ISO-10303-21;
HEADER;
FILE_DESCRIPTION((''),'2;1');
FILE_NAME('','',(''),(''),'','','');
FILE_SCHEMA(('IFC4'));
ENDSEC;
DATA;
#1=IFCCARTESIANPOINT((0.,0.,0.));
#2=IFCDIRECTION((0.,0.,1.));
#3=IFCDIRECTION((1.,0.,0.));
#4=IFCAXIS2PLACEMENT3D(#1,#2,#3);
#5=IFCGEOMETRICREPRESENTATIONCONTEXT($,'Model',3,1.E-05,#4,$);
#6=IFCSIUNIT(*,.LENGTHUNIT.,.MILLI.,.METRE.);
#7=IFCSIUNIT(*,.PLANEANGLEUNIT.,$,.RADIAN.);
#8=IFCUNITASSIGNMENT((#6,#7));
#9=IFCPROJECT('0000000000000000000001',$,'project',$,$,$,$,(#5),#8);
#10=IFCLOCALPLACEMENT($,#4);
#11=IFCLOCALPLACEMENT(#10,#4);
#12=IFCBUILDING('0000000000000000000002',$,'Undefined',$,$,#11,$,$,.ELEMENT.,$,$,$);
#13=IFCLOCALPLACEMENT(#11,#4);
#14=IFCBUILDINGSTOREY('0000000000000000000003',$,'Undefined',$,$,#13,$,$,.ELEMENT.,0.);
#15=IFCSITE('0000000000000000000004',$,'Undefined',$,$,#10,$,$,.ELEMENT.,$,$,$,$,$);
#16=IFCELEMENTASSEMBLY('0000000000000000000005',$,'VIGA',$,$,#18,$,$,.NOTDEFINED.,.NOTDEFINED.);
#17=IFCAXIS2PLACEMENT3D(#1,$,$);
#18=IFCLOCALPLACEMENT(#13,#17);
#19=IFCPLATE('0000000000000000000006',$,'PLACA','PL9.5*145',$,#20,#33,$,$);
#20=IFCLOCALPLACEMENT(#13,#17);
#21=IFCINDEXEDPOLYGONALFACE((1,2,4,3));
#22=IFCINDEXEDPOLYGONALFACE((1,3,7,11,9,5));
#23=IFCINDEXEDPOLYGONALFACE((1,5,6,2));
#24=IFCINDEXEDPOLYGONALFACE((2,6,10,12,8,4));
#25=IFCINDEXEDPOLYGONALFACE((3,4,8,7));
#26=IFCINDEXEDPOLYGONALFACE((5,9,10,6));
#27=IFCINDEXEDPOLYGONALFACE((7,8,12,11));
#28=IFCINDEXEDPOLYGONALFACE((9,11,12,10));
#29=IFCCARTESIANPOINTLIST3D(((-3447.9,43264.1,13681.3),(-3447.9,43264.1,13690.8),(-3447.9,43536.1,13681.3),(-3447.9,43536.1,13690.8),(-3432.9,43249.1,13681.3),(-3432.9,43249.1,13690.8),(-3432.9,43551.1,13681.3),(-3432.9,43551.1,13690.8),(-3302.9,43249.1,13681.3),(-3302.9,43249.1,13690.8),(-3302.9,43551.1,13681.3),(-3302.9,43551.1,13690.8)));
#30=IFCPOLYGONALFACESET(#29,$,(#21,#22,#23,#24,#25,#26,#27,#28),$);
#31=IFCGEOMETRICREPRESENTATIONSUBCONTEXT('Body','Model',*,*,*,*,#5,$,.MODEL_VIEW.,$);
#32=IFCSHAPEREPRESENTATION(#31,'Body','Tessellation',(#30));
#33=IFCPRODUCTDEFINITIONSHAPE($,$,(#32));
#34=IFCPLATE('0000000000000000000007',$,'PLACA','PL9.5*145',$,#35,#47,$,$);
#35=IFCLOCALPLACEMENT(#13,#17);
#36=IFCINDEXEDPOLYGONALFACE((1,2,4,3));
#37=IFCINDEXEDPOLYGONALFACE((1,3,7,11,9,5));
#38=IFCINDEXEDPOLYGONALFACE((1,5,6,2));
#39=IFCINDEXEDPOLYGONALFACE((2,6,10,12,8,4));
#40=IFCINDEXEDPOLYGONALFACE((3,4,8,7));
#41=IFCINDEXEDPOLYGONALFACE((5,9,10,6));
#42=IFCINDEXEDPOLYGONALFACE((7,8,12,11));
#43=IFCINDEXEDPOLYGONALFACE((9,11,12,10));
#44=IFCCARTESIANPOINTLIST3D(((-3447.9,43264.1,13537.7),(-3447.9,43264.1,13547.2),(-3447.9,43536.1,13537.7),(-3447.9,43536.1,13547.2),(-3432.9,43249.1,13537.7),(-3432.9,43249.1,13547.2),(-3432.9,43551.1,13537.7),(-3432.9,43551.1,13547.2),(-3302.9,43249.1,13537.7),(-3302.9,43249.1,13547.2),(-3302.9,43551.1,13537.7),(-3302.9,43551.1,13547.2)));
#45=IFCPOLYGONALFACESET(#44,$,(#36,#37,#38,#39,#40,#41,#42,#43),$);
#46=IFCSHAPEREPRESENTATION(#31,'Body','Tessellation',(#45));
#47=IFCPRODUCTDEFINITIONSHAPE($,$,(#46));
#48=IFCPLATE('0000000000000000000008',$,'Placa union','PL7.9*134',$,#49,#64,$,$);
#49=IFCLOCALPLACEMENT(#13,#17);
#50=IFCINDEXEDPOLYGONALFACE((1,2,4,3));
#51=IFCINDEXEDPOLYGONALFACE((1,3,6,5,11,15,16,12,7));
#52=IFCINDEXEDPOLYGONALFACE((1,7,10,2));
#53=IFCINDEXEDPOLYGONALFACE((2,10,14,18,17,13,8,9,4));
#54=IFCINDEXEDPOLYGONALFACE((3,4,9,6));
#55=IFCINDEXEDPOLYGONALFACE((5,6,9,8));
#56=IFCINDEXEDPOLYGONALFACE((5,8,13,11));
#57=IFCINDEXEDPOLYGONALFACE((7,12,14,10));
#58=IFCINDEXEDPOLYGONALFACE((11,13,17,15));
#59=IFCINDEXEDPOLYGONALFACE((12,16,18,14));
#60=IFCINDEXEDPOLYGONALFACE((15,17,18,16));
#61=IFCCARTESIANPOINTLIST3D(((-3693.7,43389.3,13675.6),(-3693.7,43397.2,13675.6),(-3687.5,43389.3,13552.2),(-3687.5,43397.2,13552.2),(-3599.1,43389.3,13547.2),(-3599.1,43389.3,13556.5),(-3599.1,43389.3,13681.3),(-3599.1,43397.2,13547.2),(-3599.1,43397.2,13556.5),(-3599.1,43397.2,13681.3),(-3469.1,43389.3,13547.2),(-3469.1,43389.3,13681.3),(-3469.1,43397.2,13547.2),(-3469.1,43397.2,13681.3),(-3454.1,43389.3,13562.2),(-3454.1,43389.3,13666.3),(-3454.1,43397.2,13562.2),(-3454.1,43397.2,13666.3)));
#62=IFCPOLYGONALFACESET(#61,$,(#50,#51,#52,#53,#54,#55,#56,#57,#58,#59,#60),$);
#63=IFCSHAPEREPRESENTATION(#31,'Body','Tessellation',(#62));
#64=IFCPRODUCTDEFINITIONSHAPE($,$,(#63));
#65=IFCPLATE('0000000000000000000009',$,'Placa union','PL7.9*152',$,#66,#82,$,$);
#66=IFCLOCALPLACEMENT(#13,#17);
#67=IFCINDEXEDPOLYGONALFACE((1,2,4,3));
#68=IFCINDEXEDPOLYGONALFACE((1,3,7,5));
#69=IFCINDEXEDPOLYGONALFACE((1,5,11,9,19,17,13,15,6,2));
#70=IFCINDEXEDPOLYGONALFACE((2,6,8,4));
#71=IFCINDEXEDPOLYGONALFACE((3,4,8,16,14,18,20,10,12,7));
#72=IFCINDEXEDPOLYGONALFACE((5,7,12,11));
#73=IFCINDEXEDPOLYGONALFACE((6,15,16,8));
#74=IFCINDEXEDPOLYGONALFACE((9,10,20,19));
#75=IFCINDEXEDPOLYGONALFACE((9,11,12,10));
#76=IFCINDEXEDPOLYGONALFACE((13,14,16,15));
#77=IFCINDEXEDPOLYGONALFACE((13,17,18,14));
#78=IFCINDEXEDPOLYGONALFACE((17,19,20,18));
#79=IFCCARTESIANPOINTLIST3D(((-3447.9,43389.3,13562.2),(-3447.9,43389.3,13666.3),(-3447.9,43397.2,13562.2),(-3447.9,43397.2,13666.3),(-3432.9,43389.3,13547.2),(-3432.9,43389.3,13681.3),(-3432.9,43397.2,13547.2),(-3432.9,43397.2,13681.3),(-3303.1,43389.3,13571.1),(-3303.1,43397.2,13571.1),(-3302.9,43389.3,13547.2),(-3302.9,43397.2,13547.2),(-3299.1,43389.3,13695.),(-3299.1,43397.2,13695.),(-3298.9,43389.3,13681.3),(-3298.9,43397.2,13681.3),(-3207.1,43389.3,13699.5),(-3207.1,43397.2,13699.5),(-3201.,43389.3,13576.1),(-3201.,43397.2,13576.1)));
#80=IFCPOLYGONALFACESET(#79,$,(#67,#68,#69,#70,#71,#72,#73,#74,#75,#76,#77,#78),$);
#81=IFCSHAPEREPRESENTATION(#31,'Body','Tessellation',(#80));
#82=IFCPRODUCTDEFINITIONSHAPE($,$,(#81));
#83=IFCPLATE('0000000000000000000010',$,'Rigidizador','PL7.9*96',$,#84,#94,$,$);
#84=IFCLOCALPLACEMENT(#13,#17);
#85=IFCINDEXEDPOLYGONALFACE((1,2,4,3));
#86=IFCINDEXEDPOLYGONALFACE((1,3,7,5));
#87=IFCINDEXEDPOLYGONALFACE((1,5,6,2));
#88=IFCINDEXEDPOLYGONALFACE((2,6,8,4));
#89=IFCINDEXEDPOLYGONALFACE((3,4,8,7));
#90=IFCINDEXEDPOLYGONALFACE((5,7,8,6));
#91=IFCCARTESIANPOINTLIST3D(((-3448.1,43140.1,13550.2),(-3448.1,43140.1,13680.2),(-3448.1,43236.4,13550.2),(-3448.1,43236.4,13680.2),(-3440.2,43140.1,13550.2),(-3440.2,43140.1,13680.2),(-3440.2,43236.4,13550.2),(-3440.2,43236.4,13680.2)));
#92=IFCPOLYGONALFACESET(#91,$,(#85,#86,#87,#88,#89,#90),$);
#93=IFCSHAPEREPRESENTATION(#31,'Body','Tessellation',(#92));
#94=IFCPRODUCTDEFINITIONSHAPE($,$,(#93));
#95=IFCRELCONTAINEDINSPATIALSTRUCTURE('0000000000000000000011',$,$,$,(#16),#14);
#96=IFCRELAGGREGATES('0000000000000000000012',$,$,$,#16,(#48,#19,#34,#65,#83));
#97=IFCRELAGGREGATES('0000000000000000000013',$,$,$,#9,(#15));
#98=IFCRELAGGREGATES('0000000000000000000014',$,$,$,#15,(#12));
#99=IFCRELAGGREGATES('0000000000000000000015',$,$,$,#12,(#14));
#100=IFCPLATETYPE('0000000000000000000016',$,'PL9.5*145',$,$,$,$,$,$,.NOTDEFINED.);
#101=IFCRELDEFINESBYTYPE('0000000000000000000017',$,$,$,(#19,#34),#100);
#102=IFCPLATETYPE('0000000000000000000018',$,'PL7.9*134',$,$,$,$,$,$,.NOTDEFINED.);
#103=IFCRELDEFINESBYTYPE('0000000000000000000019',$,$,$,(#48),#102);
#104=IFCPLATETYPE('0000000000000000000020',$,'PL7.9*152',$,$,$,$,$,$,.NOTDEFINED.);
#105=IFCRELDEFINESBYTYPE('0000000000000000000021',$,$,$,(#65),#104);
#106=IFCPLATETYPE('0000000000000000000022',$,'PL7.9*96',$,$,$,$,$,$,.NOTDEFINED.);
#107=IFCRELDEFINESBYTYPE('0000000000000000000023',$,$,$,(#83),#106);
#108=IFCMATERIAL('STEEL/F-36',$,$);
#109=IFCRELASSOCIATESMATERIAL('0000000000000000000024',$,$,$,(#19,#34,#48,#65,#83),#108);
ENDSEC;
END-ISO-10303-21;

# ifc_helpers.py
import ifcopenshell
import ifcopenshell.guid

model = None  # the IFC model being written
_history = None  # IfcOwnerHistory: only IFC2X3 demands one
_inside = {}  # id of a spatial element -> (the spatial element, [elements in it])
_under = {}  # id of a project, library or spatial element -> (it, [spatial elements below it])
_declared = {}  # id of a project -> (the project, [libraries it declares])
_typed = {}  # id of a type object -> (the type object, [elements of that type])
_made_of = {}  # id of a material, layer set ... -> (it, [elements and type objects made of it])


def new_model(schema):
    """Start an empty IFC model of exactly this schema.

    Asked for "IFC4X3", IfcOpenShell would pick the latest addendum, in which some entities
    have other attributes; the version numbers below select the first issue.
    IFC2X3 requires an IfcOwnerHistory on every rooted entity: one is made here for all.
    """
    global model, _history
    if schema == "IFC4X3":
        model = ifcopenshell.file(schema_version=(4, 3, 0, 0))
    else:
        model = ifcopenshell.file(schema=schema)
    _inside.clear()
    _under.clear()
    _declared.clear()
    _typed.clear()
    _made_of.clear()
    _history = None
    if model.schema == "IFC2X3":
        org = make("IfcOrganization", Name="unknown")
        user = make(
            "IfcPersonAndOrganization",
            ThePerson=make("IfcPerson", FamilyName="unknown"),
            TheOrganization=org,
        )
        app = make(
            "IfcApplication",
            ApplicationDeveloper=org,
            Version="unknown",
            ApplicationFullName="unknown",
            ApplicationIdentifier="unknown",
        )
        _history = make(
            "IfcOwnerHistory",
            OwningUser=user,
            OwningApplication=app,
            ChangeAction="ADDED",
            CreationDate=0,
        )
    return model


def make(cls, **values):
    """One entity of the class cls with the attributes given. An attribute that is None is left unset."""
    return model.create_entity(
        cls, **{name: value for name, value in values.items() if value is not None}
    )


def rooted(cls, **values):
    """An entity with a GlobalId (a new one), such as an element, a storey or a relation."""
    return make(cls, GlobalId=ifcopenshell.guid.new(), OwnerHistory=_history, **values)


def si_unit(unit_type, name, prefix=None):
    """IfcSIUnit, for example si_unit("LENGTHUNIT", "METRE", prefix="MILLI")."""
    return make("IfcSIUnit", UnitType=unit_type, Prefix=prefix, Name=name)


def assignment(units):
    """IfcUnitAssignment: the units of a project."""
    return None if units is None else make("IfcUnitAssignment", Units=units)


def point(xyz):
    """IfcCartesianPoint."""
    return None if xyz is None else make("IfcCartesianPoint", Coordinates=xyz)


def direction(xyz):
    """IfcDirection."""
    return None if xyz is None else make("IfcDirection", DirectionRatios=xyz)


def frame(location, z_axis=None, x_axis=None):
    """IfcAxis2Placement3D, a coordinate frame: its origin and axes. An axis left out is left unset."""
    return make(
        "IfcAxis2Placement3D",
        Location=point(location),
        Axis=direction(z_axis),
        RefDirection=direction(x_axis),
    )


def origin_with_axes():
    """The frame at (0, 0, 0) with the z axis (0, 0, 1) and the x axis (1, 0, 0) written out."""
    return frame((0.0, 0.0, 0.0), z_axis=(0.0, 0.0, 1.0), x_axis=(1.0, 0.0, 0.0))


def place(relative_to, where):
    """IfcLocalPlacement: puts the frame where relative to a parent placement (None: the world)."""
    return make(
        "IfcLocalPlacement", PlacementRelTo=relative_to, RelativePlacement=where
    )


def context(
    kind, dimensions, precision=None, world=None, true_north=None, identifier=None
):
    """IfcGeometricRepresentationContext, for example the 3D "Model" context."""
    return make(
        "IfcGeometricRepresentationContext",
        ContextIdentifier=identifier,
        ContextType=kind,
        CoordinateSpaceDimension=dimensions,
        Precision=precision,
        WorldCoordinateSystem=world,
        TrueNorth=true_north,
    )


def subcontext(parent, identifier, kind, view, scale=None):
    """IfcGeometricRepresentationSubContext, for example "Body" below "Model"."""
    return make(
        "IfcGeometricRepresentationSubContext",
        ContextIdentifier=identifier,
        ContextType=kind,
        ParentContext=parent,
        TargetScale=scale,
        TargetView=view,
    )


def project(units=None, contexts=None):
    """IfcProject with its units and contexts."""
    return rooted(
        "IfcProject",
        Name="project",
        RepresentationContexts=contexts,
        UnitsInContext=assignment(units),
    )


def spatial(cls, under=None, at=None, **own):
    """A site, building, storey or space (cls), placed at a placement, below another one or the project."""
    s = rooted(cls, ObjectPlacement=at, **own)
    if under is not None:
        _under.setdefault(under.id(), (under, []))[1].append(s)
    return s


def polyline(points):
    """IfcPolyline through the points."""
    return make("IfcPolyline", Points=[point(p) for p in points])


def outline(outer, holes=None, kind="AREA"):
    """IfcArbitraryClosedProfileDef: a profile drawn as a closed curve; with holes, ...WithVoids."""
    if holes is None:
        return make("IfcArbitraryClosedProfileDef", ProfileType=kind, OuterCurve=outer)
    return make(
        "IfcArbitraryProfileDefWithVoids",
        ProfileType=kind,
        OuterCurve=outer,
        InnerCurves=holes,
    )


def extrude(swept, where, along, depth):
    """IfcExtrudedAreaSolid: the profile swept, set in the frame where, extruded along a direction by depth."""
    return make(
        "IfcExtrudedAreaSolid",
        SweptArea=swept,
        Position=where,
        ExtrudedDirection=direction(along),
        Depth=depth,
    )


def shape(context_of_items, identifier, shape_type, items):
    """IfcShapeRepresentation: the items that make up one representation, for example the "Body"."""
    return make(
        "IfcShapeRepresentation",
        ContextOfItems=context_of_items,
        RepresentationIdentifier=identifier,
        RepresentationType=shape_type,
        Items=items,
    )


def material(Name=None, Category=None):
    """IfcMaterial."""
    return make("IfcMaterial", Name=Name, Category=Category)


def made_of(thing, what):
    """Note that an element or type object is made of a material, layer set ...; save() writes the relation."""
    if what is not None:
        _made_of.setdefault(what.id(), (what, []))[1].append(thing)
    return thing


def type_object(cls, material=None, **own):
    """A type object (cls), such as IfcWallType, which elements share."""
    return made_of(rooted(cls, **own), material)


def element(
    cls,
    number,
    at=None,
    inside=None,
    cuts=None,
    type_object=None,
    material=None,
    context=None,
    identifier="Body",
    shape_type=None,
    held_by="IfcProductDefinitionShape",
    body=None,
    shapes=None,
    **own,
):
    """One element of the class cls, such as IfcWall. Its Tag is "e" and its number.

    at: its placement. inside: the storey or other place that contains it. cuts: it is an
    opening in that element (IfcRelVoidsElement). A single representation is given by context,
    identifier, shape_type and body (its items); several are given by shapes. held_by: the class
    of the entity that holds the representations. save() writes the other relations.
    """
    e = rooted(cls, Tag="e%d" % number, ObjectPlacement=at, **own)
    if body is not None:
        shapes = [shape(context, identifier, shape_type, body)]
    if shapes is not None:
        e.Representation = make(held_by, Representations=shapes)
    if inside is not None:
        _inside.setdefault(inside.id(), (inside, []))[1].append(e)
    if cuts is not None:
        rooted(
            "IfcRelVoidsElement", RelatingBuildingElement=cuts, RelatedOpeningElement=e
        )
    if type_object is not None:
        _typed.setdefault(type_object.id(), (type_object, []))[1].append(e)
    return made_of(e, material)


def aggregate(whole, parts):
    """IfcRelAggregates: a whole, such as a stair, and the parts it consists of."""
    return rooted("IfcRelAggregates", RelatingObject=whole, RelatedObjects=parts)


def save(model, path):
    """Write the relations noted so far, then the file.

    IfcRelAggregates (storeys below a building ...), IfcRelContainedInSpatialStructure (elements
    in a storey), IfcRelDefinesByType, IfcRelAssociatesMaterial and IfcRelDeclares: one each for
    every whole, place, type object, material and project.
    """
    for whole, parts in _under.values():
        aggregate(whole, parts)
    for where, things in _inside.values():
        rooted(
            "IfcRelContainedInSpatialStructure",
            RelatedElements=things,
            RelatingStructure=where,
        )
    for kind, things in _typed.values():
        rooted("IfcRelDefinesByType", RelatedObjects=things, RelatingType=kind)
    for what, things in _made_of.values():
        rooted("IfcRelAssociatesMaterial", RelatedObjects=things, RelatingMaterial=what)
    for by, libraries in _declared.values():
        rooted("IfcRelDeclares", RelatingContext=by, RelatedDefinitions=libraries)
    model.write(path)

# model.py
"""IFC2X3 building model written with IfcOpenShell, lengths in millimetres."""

from ifc_helpers import new_model, si_unit, frame, origin_with_axes, place, context, subcontext, project, spatial, polyline, outline, extrude, material, type_object, element, aggregate, save


model = new_model("IFC2X3")

# Units and contexts
model_context = context("Model", 3, precision=1e-05, world=origin_with_axes())
body_context = subcontext(model_context, "Body", "Model", "MODEL_VIEW")
ifc_project = project(units=[si_unit("LENGTHUNIT", "METRE", prefix="MILLI"), si_unit("PLANEANGLEUNIT", "RADIAN")], contexts=[model_context])

# Site, building, storey
site_placement = place(None, origin_with_axes())
site = spatial("IfcSite", under=ifc_project, at=site_placement, Name="Undefined", CompositionType="ELEMENT")
building_placement = place(site_placement, origin_with_axes())
building = spatial("IfcBuilding", under=site, at=building_placement, Name="Undefined", CompositionType="ELEMENT")
storey_placement = place(building_placement, origin_with_axes())
storey = spatial("IfcBuildingStorey", under=building, at=storey_placement, Name="Undefined", CompositionType="ELEMENT", Elevation=0.0)

# Shared definitions
ifc_material_1 = material(Name="STEEL/F-36")

# Element assembly
assembly_1_placement = place(storey_placement, origin_with_axes())
assembly_1 = element("IfcElementAssembly", 1, at=assembly_1_placement, inside=storey, Name="VIGA", AssemblyPlace="NOTDEFINED", PredefinedType="NOTDEFINED")

# Plates
plate_type_1 = type_object("IfcPlateType", Name="PL9.5*145", PredefinedType="NOTDEFINED")
plate_1_placement = place(assembly_1_placement, frame((-3447.9, 43249.1, 13686.1), z_axis=(0.000002, 0.000009, 1.0), x_axis=(1.0, 0.0, -0.000002)))
plate_1 = element("IfcPlate", 2, at=plate_1_placement, type_object=plate_type_1, material=ifc_material_1, Name="PLACA", Description="PL9.5*145", context=body_context, shape_type="SweptSolid", body=[
    extrude(outline(polyline([(0.0, 15.0), (15.0, 0.0), (145.0, 0.0), (145.0, 301.9), (15.0, 301.9), (0.0, 286.9), (0.0, 15.0)])), frame((0.0, 0.0, -4.8), z_axis=(0.0, 0.0, 1.0), x_axis=(1.0, 0.0, 0.0)), (0.0, 0.0, 1.0), 9.5),
])
plate_2_placement = place(assembly_1_placement, frame((-3447.9, 43249.1, 13542.5), z_axis=(0.000002, 0.000009, 1.0), x_axis=(1.0, 0.0, -0.000002)))
plate_2 = element("IfcPlate", 3, at=plate_2_placement, type_object=plate_type_1, material=ifc_material_1, Name="PLACA", Description="PL9.5*145", context=body_context, shape_type="SweptSolid", body=[
    extrude(outline(polyline([(0.0, 15.0), (15.0, 0.0), (145.0, 0.0), (145.0, 301.9), (15.0, 301.9), (0.0, 286.9), (0.0, 15.0)])), frame((0.0, 0.0, -4.8), z_axis=(0.0, 0.0, 1.0), x_axis=(1.0, 0.0, 0.0)), (0.0, 0.0, 1.0), 9.5),
])
plate_type_2 = type_object("IfcPlateType", Name="PL7.9*134", PredefinedType="NOTDEFINED")
plate_3_placement = place(assembly_1_placement, frame((-3454.1, 43393.2, 13681.3), z_axis=(0.0, -1.0, 0.0), x_axis=(-1.0, 0.0, 0.000013)))
plate_3 = element("IfcPlate", 4, at=plate_3_placement, type_object=plate_type_2, material=ifc_material_1, Name="Placa union", Description="PL7.9*134", context=body_context, shape_type="SweptSolid", body=[
    extrude(outline(polyline([(0.0, 15.0), (15.0, 0.0), (145.0, 0.0), (239.6, 5.7), (233.4, 129.1), (145.0, 124.8), (145.0, 134.1), (15.0, 134.1), (0.0, 119.1), (0.0, 15.0)])), frame((0.0, 0.0, -4.0), z_axis=(0.0, 0.0, 1.0), x_axis=(1.0, 0.0, 0.0)), (0.0, 0.0, 1.0), 7.9),
])
plate_type_3 = type_object("IfcPlateType", Name="PL7.9*152", PredefinedType="NOTDEFINED")
plate_4_placement = place(assembly_1_placement, frame((-3447.9, 43393.2, 13681.3), z_axis=(0.0, 1.0, 0.0), x_axis=(1.0, 0.0, 0.0)))
plate_4 = element("IfcPlate", 5, at=plate_4_placement, type_object=plate_type_3, material=ifc_material_1, Name="Placa union", Description="PL7.9*152", context=body_context, shape_type="SweptSolid", body=[
    extrude(outline(polyline([(0.0, 15.0), (15.0, 0.0), (149.0, 0.0), (148.8, -13.7), (240.8, -18.2), (246.9, 105.2), (144.8, 110.2), (145.0, 134.1), (15.0, 134.1), (0.0, 119.1), (0.0, 15.0)])), frame((0.0, 0.0, -4.0), z_axis=(0.0, 0.0, 1.0), x_axis=(1.0, 0.0, 0.0)), (0.0, 0.0, 1.0), 7.9),
])
plate_type_4 = type_object("IfcPlateType", Name="PL7.9*96", PredefinedType="NOTDEFINED")
plate_5_placement = place(assembly_1_placement, frame((-3444.1, 43236.4, 13680.2), z_axis=(-1.0, 0.0, 0.0), x_axis=(0.0, 0.0, -1.0)))
plate_5 = element("IfcPlate", 6, at=plate_5_placement, type_object=plate_type_4, material=ifc_material_1, Name="Rigidizador", Description="PL7.9*96", context=body_context, shape_type="SweptSolid", body=[
    extrude(outline(polyline([(0.0, 0.0), (130.0, 0.0), (130.0, 96.3), (0.0, 96.3), (0.0, 0.0)])), frame((0.0, 0.0, -4.0), z_axis=(0.0, 0.0, 1.0), x_axis=(1.0, 0.0, 0.0)), (0.0, 0.0, 1.0), 7.9),
])

aggregate(assembly_1, [plate_3, plate_1, plate_2, plate_4, plate_5])

save(model, "model.ifc")
